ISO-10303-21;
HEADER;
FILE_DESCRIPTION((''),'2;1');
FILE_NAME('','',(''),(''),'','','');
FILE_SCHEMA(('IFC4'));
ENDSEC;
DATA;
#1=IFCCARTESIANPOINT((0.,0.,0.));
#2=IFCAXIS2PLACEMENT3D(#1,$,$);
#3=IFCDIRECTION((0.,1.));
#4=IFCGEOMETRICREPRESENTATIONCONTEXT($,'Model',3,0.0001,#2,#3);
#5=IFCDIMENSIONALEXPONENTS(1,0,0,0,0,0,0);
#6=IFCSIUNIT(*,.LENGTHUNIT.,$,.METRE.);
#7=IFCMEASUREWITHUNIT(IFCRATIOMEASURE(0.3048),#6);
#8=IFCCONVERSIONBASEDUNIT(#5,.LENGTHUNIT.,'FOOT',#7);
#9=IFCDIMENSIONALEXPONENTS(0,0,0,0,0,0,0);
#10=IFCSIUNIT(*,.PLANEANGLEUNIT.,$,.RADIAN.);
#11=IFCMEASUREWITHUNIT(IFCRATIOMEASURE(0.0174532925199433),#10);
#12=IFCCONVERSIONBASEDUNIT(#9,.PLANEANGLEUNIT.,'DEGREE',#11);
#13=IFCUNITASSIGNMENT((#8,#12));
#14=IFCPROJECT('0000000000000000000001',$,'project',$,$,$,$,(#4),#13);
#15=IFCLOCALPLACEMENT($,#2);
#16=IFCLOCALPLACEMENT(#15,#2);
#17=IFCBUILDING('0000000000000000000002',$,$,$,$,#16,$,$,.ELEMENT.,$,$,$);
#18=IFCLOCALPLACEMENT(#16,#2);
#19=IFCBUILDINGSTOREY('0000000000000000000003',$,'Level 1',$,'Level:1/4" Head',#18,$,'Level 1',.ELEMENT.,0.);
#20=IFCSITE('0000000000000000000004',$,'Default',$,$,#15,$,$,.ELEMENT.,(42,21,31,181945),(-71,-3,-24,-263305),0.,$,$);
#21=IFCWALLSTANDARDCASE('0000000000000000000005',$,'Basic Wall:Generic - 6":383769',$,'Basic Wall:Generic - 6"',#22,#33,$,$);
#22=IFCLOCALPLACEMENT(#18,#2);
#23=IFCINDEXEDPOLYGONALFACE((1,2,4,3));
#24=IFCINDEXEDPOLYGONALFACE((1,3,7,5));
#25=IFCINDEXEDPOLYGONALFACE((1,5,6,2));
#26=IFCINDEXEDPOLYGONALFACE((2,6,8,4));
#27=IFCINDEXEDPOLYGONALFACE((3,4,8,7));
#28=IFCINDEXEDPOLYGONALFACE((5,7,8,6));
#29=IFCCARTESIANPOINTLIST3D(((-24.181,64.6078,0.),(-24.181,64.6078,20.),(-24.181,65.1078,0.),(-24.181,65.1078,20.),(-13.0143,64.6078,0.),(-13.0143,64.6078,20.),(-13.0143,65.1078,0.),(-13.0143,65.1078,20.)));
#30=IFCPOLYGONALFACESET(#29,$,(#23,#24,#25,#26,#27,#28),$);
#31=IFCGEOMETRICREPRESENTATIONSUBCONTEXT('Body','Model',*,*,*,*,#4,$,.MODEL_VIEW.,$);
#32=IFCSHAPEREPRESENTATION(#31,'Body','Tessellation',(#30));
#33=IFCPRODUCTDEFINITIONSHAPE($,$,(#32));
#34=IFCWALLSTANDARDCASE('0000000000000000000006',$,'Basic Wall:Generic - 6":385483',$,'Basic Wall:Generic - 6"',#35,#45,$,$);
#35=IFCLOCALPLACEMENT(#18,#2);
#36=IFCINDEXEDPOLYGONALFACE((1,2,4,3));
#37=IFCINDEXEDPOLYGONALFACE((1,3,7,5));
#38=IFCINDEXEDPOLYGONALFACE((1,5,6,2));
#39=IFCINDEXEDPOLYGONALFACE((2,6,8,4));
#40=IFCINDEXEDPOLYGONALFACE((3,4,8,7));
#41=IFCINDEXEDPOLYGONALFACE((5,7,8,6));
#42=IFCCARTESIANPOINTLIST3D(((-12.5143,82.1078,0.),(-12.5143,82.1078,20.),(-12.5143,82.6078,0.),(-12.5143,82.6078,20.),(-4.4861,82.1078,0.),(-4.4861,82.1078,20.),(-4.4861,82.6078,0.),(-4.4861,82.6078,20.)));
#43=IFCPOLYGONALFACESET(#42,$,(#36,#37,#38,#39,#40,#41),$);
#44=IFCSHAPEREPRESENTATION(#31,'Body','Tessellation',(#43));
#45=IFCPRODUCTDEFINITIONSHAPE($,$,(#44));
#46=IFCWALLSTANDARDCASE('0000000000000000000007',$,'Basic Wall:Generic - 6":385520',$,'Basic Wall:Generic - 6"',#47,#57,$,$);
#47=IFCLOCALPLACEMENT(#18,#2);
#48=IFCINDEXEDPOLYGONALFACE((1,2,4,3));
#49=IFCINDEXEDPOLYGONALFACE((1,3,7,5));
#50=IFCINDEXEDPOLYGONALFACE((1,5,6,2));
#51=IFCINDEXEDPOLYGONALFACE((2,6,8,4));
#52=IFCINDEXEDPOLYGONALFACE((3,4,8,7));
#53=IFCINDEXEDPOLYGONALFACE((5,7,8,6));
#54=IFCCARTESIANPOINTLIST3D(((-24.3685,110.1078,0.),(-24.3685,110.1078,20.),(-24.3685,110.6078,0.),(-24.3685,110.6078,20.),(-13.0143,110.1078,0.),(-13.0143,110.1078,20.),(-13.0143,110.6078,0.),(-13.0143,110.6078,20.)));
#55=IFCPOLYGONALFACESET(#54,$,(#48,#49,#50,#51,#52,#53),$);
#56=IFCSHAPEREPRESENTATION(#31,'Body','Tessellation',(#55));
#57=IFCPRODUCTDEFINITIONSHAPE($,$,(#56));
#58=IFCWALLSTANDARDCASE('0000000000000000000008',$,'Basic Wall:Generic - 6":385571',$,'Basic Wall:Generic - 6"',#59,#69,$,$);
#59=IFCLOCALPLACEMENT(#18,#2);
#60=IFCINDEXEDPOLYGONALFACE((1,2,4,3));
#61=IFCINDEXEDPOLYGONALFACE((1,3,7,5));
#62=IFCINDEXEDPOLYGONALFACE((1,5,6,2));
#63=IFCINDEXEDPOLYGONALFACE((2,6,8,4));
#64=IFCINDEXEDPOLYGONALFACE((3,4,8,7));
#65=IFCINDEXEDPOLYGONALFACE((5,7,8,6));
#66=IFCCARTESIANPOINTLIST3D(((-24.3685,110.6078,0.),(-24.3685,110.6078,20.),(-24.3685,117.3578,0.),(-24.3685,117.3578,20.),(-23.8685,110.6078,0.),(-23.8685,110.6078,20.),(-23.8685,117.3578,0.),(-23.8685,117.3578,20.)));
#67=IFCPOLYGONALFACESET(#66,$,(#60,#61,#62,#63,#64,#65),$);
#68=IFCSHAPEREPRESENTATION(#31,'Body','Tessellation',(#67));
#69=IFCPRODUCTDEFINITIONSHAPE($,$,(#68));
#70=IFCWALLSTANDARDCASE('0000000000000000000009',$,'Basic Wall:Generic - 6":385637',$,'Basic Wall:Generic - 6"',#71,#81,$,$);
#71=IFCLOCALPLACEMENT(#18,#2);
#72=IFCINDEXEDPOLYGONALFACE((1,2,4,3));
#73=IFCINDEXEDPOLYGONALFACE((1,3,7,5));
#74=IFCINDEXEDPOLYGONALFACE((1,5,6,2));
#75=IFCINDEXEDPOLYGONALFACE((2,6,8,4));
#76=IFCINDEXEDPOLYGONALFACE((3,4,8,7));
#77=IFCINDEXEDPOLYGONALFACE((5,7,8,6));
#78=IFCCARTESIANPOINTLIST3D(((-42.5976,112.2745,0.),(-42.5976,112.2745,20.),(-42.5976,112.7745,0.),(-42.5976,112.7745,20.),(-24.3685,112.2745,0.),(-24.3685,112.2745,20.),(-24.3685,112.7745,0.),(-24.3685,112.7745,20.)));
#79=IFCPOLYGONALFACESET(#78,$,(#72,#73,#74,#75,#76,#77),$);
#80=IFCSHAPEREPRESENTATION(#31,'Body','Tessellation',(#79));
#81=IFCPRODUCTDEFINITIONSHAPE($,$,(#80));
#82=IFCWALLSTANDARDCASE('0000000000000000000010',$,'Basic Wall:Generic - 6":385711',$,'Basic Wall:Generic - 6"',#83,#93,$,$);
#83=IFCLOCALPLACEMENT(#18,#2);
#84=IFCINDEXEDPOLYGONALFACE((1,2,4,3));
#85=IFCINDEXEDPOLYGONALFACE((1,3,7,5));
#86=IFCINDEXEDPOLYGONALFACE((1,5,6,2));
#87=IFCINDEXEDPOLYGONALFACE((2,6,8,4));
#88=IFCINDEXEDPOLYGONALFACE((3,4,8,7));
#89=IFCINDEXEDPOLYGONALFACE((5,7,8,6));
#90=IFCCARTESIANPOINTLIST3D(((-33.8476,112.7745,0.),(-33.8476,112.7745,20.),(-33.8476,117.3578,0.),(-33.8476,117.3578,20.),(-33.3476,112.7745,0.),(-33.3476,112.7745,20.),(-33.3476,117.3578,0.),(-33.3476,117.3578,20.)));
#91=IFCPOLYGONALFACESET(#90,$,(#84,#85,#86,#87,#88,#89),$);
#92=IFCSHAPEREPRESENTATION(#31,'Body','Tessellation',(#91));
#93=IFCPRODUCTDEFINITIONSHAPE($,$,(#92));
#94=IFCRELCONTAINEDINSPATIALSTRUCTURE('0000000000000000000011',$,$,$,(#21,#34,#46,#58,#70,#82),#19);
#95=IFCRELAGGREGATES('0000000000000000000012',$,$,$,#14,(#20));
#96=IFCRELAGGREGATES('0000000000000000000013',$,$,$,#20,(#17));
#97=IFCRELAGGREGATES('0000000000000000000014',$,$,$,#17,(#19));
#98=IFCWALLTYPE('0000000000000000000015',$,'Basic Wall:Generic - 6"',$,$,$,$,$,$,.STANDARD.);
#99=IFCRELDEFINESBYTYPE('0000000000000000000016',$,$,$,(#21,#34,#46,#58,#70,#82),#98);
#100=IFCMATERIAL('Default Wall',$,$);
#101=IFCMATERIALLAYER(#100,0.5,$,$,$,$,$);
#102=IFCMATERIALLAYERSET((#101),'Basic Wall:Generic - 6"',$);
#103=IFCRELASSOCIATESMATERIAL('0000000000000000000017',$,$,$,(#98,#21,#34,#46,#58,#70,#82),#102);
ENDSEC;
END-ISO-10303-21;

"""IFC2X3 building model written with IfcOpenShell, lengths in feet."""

from ifc_helpers import new_model, entity, si_unit, converted_unit, direction, frame, frame_2d, origin, place, context, subcontext, project, spatial, rectangle, extrude, material, layer, layer_set, layer_usage, type_object, element, save


model = new_model("IFC2X3")

# Units and contexts
model_context = context("Model", 3, precision=0.0001, world=origin(), true_north=direction((0.0, 1.0)))
body_context = subcontext(model_context, "Body", "Model", "MODEL_VIEW")
ifc_project = project(units=[converted_unit("LENGTHUNIT", "FOOT", entity("IfcRatioMeasure", 0.3048), si_unit("LENGTHUNIT", "METRE"), dimensions=[1, 0, 0, 0, 0, 0, 0]), converted_unit("PLANEANGLEUNIT", "DEGREE", entity("IfcRatioMeasure", 0.0174532925199433), si_unit("PLANEANGLEUNIT", "RADIAN"), dimensions=[0, 0, 0, 0, 0, 0, 0])], contexts=[model_context])

# Site, building, storey
site_placement = place(None, origin())
site = spatial("IfcSite", under=ifc_project, at=site_placement, Name="Default", CompositionType="ELEMENT", RefLatitude=(42, 21, 31, 181945), RefLongitude=(-71, -3, -24, -263305), RefElevation=0.0)
building_placement = place(site_placement, origin())
building = spatial("IfcBuilding", under=site, at=building_placement, CompositionType="ELEMENT")
storey_placement = place(building_placement, origin())
storey = spatial("IfcBuildingStorey", under=building, at=storey_placement, Name="Level 1", ObjectType="Level:1/4\" Head", LongName="Level 1", CompositionType="ELEMENT", Elevation=0.0)

# Shared definitions
ifc_material = material(Name="Default Wall")
ifc_layer = layer(ifc_material, 0.5)
ifc_layer_set = layer_set([ifc_layer], Name="Basic Wall:Generic - 6\"")
wall_type = type_object("IfcWallType", Name="Basic Wall:Generic - 6\"", PredefinedType="STANDARD", material=ifc_layer_set)

# Walls
ifc_layer_usage_1 = layer_usage(ifc_layer_set, "AXIS2", "NEGATIVE", 0.25)
wall_1_placement = place(storey_placement, frame((-24.181, 64.8578, 0.0)))
element("IfcWallStandardCase", 1, at=wall_1_placement, inside=storey, type_object=wall_type, material=ifc_layer_usage_1, Name="Basic Wall:Generic - 6\":383769", ObjectType="Basic Wall:Generic - 6\"", context=body_context, shape_type="SweptSolid", body=[
    extrude(rectangle(XDim=11.1667, YDim=0.5, at=frame_2d((5.5833, 0.0), x_axis=(-1.0, 0.0))), origin(), (0.0, 0.0, 1.0), 20.0),
])
ifc_layer_usage_2 = layer_usage(ifc_layer_set, "AXIS2", "NEGATIVE", 0.25)
wall_2_placement = place(storey_placement, frame((-12.5143, 82.3578, 0.0)))
element("IfcWallStandardCase", 2, at=wall_2_placement, inside=storey, type_object=wall_type, material=ifc_layer_usage_2, Name="Basic Wall:Generic - 6\":385483", ObjectType="Basic Wall:Generic - 6\"", context=body_context, shape_type="SweptSolid", body=[
    extrude(rectangle(XDim=8.0282, YDim=0.5, at=frame_2d((4.0141, 0.0), x_axis=(-1.0, 0.0))), origin(), (0.0, 0.0, 1.0), 20.0),
])
ifc_layer_usage_3 = layer_usage(ifc_layer_set, "AXIS2", "NEGATIVE", 0.25)
wall_3_placement = place(storey_placement, frame((-13.0143, 110.3578, 0.0), z_axis=(0.0, 0.0, 1.0), x_axis=(-1.0, 0.0, 0.0)))
element("IfcWallStandardCase", 3, at=wall_3_placement, inside=storey, type_object=wall_type, material=ifc_layer_usage_3, Name="Basic Wall:Generic - 6\":385520", ObjectType="Basic Wall:Generic - 6\"", context=body_context, shape_type="SweptSolid", body=[
    extrude(rectangle(XDim=11.3542, YDim=0.5, at=frame_2d((5.6771, 0.0), x_axis=(-1.0, 0.0))), origin(), (0.0, 0.0, 1.0), 20.0),
])
ifc_layer_usage_4 = layer_usage(ifc_layer_set, "AXIS2", "NEGATIVE", 0.25)
wall_4_placement = place(storey_placement, frame((-24.1185, 110.6078, 0.0), z_axis=(0.0, 0.0, 1.0), x_axis=(0.0, 1.0, 0.0)))
element("IfcWallStandardCase", 4, at=wall_4_placement, inside=storey, type_object=wall_type, material=ifc_layer_usage_4, Name="Basic Wall:Generic - 6\":385571", ObjectType="Basic Wall:Generic - 6\"", context=body_context, shape_type="SweptSolid", body=[
    extrude(rectangle(XDim=6.75, YDim=0.5, at=frame_2d((3.375, 0.0), x_axis=(-1.0, 0.0))), origin(), (0.0, 0.0, 1.0), 20.0),
])
ifc_layer_usage_5 = layer_usage(ifc_layer_set, "AXIS2", "POSITIVE", -0.25)
wall_5_placement = place(storey_placement, frame((-24.3685, 112.5245, 0.0), z_axis=(0.0, 0.0, 1.0), x_axis=(-1.0, 0.0, 0.0)))
element("IfcWallStandardCase", 5, at=wall_5_placement, inside=storey, type_object=wall_type, material=ifc_layer_usage_5, Name="Basic Wall:Generic - 6\":385637", ObjectType="Basic Wall:Generic - 6\"", context=body_context, shape_type="SweptSolid", body=[
    extrude(rectangle(XDim=18.2292, YDim=0.5, at=frame_2d((9.1146, 0.0), x_axis=(-1.0, 0.0))), origin(), (0.0, 0.0, 1.0), 20.0),
])
ifc_layer_usage_6 = layer_usage(ifc_layer_set, "AXIS2", "NEGATIVE", 0.25)
wall_6_placement = place(storey_placement, frame((-33.5976, 117.3578, 0.0), z_axis=(0.0, 0.0, 1.0), x_axis=(0.0, -1.0, 0.0)))
element("IfcWallStandardCase", 6, at=wall_6_placement, inside=storey, type_object=wall_type, material=ifc_layer_usage_6, Name="Basic Wall:Generic - 6\":385711", ObjectType="Basic Wall:Generic - 6\"", context=body_context, shape_type="SweptSolid", body=[
    extrude(rectangle(XDim=4.5833, YDim=0.5, at=frame_2d((2.2917, 0.0), x_axis=(-1.0, 0.0))), origin(), (0.0, 0.0, 1.0), 20.0),
])

save(model, "model.ifc")
